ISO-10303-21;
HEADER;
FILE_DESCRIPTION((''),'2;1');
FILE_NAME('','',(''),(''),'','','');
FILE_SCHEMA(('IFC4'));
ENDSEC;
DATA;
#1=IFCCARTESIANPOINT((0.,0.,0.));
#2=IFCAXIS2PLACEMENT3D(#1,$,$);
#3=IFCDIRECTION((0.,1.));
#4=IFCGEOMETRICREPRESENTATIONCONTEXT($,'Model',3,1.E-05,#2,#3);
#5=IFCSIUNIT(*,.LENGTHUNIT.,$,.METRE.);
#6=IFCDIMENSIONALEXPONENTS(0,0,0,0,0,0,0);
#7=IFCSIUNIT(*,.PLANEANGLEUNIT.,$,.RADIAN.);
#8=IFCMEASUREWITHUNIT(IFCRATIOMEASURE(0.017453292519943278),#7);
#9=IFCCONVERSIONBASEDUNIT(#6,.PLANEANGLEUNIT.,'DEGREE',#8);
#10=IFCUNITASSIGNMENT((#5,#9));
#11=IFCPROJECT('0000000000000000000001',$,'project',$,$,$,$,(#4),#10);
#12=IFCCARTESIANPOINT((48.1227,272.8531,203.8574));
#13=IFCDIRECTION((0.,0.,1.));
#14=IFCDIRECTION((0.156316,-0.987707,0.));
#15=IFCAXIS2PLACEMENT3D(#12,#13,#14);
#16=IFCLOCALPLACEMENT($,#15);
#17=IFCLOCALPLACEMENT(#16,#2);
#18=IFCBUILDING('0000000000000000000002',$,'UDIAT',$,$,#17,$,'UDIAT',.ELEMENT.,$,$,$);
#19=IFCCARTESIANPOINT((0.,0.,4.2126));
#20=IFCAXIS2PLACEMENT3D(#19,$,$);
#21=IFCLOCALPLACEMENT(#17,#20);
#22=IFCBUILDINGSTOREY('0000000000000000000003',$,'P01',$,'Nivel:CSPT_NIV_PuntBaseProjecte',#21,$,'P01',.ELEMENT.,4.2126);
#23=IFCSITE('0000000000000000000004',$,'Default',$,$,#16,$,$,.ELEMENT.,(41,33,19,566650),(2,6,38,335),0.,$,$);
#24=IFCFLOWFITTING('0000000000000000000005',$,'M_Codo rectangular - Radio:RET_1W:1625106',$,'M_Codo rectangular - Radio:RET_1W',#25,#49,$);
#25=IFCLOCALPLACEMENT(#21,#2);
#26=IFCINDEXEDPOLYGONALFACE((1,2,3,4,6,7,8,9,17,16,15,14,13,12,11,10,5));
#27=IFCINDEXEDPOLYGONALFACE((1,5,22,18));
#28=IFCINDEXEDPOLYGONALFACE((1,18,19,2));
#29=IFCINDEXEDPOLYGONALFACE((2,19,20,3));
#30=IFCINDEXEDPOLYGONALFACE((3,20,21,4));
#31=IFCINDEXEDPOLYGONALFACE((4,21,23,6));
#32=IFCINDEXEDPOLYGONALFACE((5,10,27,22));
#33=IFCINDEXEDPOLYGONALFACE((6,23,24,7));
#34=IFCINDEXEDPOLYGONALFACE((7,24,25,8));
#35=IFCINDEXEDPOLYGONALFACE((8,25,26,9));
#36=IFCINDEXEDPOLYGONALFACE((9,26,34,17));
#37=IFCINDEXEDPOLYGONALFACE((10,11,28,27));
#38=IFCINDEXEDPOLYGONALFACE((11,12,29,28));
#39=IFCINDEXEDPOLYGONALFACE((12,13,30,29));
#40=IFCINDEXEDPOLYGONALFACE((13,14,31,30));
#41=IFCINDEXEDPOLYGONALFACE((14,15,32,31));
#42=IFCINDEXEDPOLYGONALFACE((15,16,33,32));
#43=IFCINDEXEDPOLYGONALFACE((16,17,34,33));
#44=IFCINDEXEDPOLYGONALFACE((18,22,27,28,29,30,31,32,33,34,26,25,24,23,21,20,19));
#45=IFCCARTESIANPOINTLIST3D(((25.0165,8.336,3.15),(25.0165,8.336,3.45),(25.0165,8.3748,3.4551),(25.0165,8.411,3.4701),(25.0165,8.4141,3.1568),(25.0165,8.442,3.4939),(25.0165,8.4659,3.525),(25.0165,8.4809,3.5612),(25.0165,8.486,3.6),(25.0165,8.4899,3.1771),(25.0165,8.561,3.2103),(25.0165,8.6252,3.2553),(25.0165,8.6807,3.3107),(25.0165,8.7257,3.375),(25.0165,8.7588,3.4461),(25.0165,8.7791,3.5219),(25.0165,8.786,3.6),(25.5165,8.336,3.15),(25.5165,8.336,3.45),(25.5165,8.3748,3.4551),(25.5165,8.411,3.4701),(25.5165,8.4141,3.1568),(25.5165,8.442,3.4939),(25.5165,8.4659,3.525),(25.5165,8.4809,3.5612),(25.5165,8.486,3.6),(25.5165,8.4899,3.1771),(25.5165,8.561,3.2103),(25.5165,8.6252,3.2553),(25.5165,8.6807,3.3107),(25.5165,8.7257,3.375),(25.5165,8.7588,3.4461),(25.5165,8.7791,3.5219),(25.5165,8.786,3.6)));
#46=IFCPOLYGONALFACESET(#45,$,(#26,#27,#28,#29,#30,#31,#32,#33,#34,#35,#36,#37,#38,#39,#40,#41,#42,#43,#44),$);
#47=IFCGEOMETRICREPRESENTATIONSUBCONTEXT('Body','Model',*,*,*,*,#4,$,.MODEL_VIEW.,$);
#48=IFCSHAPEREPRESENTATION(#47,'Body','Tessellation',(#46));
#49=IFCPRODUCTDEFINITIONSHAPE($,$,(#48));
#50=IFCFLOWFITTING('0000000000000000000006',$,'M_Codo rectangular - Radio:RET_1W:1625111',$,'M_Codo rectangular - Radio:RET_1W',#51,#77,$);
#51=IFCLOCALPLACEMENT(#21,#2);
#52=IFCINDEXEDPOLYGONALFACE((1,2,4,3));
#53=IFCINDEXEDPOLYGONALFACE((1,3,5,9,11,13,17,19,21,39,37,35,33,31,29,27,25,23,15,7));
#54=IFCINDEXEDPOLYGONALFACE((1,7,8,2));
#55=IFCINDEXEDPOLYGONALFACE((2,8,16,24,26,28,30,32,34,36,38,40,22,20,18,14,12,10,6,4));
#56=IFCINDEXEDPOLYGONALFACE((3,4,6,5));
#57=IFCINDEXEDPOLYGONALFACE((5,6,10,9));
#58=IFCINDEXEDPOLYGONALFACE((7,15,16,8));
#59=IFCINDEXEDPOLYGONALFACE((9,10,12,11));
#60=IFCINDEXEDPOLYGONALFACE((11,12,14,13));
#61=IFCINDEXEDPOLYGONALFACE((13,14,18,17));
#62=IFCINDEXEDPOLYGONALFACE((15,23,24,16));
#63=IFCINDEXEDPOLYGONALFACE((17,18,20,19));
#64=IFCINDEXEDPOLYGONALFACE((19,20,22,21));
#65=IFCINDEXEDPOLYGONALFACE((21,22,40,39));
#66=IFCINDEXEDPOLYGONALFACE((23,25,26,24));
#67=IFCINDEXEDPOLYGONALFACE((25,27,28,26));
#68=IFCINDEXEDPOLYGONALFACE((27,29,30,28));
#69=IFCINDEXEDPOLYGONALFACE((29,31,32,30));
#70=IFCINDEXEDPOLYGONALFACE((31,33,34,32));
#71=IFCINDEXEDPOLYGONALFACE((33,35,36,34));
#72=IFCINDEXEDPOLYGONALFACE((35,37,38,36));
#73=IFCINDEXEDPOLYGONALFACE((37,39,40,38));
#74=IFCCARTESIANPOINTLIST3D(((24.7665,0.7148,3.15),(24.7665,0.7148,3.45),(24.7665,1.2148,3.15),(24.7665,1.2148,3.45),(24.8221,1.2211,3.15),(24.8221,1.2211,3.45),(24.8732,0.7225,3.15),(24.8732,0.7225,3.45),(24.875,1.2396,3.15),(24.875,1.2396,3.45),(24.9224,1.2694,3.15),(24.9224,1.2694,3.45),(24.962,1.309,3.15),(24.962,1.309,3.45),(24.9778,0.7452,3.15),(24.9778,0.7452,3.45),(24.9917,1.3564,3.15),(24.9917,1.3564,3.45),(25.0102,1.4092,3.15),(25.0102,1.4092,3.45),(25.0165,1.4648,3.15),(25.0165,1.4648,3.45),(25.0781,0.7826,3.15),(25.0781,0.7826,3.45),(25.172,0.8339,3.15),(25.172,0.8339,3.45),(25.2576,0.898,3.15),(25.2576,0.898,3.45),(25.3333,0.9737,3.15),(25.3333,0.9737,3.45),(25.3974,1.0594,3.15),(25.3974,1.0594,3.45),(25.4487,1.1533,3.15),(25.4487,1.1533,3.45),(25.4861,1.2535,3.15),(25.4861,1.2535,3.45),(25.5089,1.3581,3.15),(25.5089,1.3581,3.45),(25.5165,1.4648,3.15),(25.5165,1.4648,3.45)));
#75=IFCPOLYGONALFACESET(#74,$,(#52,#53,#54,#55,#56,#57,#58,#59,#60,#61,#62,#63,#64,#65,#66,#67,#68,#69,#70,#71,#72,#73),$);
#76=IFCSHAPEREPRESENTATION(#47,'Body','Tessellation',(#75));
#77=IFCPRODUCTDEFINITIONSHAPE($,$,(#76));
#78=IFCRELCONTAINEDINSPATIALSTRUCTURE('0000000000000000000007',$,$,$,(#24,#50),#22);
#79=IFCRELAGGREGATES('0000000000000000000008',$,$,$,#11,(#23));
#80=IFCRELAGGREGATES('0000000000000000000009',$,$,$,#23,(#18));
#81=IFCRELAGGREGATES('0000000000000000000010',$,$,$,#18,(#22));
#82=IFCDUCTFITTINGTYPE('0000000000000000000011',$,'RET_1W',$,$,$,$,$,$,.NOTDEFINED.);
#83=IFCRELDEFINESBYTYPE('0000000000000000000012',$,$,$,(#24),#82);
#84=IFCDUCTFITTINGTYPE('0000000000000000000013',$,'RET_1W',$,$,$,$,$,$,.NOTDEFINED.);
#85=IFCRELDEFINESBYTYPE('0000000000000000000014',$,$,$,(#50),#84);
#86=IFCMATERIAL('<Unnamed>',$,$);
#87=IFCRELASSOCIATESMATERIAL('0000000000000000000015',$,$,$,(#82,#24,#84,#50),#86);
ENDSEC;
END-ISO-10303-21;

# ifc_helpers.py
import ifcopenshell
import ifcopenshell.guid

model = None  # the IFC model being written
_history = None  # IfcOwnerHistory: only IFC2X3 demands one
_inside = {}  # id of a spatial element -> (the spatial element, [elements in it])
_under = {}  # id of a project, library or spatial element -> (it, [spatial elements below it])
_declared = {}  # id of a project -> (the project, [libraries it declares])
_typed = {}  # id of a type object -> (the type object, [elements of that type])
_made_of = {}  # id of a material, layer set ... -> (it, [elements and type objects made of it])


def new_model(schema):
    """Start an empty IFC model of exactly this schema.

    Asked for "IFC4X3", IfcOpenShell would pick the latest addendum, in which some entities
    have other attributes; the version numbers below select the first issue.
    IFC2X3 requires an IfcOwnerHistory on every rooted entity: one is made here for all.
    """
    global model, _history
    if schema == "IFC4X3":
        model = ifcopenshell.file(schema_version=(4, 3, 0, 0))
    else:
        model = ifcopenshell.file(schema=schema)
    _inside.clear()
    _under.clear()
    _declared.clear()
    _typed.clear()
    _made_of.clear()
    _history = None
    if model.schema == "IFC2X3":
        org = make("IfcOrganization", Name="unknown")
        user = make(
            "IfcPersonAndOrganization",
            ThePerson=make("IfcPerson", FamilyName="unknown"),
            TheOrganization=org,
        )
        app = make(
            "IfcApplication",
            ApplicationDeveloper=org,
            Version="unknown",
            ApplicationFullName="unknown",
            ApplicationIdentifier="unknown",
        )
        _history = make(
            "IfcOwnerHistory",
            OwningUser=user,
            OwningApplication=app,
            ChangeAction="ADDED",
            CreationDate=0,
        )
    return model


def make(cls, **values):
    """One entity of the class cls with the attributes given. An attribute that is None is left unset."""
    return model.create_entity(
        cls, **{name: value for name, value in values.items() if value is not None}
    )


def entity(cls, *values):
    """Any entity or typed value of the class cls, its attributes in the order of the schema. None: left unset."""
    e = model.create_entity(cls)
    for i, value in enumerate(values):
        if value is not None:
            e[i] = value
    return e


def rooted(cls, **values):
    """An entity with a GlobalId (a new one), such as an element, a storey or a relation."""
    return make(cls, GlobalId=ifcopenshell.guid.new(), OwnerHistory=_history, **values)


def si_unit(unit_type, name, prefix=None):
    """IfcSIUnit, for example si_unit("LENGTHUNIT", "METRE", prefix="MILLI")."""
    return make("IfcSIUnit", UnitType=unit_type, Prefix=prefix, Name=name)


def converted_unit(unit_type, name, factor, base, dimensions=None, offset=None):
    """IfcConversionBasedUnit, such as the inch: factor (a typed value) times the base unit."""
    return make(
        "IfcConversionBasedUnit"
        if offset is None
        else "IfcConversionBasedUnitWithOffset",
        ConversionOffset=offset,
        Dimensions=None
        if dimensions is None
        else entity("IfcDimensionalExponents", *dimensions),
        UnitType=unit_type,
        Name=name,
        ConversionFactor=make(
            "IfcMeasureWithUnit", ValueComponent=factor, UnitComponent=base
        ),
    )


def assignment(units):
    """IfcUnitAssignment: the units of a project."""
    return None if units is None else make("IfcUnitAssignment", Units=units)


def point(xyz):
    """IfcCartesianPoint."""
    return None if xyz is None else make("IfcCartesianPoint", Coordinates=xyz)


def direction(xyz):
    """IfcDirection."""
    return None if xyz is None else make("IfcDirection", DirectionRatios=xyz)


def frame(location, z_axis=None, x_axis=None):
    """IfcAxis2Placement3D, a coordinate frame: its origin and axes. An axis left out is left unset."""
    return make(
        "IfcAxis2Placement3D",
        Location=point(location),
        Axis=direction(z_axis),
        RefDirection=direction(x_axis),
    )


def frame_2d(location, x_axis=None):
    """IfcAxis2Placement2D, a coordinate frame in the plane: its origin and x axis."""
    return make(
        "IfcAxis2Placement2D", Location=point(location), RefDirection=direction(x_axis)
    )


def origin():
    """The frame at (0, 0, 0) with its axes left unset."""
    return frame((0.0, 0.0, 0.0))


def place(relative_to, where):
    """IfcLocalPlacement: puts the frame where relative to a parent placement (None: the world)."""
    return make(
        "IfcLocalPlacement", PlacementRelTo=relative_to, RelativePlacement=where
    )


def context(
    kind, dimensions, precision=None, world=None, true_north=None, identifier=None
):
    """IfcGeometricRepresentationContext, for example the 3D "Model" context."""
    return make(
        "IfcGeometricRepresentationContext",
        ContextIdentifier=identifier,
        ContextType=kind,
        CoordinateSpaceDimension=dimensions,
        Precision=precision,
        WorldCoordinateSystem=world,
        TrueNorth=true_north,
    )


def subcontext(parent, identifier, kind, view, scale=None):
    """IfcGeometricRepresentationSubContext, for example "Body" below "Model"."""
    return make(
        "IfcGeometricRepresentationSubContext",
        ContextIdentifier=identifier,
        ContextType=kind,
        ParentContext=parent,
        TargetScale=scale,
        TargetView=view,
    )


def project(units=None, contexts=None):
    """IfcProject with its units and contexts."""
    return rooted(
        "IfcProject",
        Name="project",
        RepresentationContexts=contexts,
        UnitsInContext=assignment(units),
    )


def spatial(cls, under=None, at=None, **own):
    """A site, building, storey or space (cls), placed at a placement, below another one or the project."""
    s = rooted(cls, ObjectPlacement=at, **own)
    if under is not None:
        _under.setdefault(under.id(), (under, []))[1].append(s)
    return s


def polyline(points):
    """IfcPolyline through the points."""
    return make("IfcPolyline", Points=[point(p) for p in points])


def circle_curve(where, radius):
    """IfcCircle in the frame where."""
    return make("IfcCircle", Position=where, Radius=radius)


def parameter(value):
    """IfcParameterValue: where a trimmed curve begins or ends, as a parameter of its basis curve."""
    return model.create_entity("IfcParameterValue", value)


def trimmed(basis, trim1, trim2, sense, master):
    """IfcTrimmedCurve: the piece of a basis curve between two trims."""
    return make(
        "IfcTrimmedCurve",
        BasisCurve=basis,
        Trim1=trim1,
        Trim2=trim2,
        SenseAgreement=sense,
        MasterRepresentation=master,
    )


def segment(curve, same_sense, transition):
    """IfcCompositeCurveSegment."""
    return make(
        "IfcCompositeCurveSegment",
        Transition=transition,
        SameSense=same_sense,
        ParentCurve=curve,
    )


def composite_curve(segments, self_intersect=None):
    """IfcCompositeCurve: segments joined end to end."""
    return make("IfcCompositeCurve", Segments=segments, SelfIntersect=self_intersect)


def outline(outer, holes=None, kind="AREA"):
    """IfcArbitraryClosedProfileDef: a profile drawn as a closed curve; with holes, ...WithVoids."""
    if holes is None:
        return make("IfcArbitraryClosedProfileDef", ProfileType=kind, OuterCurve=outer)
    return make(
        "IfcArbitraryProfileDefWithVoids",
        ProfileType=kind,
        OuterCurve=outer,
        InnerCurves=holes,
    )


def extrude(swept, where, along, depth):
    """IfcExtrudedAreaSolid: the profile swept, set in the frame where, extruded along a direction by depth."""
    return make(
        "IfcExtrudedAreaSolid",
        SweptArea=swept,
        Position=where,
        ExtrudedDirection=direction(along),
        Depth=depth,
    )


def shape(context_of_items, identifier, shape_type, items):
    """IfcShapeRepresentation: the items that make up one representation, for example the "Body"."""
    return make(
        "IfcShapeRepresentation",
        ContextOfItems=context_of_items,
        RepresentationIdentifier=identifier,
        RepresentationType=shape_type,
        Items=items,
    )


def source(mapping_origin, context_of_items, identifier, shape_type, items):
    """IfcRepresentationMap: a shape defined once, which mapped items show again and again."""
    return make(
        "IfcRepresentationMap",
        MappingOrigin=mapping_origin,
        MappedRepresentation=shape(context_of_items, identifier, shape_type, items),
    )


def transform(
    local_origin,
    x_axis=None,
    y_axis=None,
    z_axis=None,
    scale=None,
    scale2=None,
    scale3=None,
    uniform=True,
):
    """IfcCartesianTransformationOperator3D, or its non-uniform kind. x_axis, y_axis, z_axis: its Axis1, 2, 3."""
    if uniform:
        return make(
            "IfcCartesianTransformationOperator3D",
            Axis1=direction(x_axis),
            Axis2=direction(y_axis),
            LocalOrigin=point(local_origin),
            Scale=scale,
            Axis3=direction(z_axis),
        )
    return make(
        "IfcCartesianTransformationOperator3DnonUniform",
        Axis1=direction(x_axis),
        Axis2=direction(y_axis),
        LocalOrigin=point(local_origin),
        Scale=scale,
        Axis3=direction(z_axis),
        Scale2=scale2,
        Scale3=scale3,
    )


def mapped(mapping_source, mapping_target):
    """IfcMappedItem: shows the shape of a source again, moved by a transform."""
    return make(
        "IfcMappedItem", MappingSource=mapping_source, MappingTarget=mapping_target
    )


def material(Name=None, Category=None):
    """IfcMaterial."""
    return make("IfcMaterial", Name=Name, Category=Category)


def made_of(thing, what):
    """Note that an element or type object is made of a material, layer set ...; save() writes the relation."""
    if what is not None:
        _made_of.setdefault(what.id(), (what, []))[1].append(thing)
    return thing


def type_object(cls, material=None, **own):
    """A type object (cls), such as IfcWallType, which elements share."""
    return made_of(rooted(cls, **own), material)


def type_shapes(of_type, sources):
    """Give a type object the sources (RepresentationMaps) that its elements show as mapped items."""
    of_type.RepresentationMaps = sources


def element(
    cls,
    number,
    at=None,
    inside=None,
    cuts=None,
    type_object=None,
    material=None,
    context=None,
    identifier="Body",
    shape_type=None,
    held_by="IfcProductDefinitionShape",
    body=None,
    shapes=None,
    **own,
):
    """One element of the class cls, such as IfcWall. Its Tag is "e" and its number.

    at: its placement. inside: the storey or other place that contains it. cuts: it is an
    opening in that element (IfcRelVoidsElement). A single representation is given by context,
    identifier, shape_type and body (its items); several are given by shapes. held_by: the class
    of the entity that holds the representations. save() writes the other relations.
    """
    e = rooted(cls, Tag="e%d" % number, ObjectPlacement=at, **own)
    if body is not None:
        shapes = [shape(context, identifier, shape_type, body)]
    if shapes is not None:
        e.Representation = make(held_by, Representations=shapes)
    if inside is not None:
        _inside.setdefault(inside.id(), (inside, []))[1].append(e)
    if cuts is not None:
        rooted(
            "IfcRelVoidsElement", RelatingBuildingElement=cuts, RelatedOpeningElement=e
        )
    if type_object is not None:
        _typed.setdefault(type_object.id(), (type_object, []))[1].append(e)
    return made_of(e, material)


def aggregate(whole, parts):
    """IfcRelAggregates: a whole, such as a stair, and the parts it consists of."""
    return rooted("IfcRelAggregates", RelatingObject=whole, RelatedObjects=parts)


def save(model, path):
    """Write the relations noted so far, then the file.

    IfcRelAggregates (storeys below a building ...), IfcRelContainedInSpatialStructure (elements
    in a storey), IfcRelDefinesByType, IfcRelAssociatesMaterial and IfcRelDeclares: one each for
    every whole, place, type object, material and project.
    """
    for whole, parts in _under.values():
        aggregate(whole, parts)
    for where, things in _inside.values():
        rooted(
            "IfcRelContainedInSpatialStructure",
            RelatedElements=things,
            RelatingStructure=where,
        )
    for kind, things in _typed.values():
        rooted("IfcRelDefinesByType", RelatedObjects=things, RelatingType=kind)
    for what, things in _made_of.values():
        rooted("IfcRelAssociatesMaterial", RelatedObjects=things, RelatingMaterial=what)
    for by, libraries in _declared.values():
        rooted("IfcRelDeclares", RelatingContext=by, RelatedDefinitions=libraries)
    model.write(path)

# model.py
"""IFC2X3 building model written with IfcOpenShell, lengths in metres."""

from ifc_helpers import new_model, entity, si_unit, converted_unit, direction, frame, frame_2d, origin, place, context, subcontext, project, spatial, polyline, circle_curve, parameter, trimmed, segment, composite_curve, outline, extrude, source, transform, mapped, material, type_object, type_shapes, element, save


model = new_model("IFC2X3")

# Units and contexts
model_context = context("Model", 3, precision=1e-05, world=origin(), true_north=direction((0.0, 1.0)))
body_context = subcontext(model_context, "Body", "Model", "MODEL_VIEW")
ifc_project = project(units=[si_unit("LENGTHUNIT", "METRE"), converted_unit("PLANEANGLEUNIT", "DEGREE", entity("IfcRatioMeasure", 0.017453292519943278), si_unit("PLANEANGLEUNIT", "RADIAN"), dimensions=[0, 0, 0, 0, 0, 0, 0])], contexts=[model_context])

# Site, building, storey
site_placement = place(None, frame((48.1227, 272.8531, 203.8574), z_axis=(0.0, 0.0, 1.0), x_axis=(0.156316, -0.987707, 0.0)))
site = spatial("IfcSite", under=ifc_project, at=site_placement, Name="Default", CompositionType="ELEMENT", RefLatitude=(41, 33, 19, 566650), RefLongitude=(2, 6, 38, 335), RefElevation=0.0)
building_placement = place(site_placement, origin())
building = spatial("IfcBuilding", under=site, at=building_placement, Name="UDIAT", LongName="UDIAT", CompositionType="ELEMENT")
storey_placement = place(building_placement, frame((0.0, 0.0, 4.2126)))
storey = spatial("IfcBuildingStorey", under=building, at=storey_placement, Name="P01", ObjectType="Nivel:CSPT_NIV_PuntBaseProjecte", LongName="P01", CompositionType="ELEMENT", Elevation=4.2126)

# Flow fittings
ifc_material_1 = material(Name="<Unnamed>")
duct_fitting_type_1 = type_object("IfcDuctFittingType", Name="RET_1W", PredefinedType="NOTDEFINED", material=ifc_material_1)
shared_shape_1 = source(origin(), body_context, "Body", "SweptSolid", [
    extrude(outline(composite_curve([segment(polyline([(-0.3, -0.15), (0.0, -0.15)]), True, "CONTINUOUS"), segment(trimmed(circle_curve(frame_2d((0.15, -0.15), x_axis=(0.0, 1.0)), 0.15), [parameter(0.0)], [parameter(90.0)], True, "PARAMETER"), False, "CONTINUOUS"), segment(polyline([(0.15, 0.0), (0.15, 0.3)]), True, "CONTINUOUS"), segment(trimmed(circle_curve(frame_2d((0.15, -0.15), x_axis=(0.0, 1.0)), 0.45), [parameter(0.0)], [parameter(90.0)], True, "PARAMETER"), True, "CONTINUOUS")], self_intersect=False)), frame((-0.15, 0.15, -0.25), z_axis=(0.0, 0.0, 1.0), x_axis=(-1.0, 0.0, 0.0)), (0.0, 0.0, 1.0), 0.5),
])
type_shapes(duct_fitting_type_1, [shared_shape_1])
flow_fitting_1_placement = place(storey_placement, frame((25.2665, 8.636, 3.3), z_axis=(1.0, 0.0, 0.0), x_axis=(0.0, 1.0, 0.0)))
element("IfcFlowFitting", 1, at=flow_fitting_1_placement, inside=storey, type_object=duct_fitting_type_1, material=ifc_material_1, Name="M_Codo rectangular - Radio:RET_1W:1625106", ObjectType="M_Codo rectangular - Radio:RET_1W", context=body_context, shape_type="MappedRepresentation", body=[
    mapped(shared_shape_1, transform((0.0, 0.0, 0.0), scale=1.0)),
])
duct_fitting_type_2 = type_object("IfcDuctFittingType", Name="RET_1W", PredefinedType="NOTDEFINED", material=ifc_material_1)
shared_shape_2 = source(origin(), body_context, "Body", "SweptSolid", [
    extrude(outline(composite_curve([segment(polyline([(-0.5, -0.25), (0.0, -0.25)]), True, "CONTINUOUS"), segment(trimmed(circle_curve(frame_2d((0.25, -0.25), x_axis=(0.0, 1.0)), 0.25), [parameter(0.0)], [parameter(90.0)], True, "PARAMETER"), False, "CONTINUOUS"), segment(polyline([(0.25, 0.0), (0.25, 0.5)]), True, "CONTINUOUS"), segment(trimmed(circle_curve(frame_2d((0.25, -0.25), x_axis=(0.0, 1.0)), 0.75), [parameter(0.0)], [parameter(90.0)], True, "PARAMETER"), True, "CONTINUOUS")], self_intersect=False)), frame((-0.25, 0.25, -0.15), z_axis=(0.0, 0.0, 1.0), x_axis=(-1.0, 0.0, 0.0)), (0.0, 0.0, 1.0), 0.3),
])
type_shapes(duct_fitting_type_2, [shared_shape_2])
flow_fitting_2_placement = place(storey_placement, frame((25.2665, 0.9648, 3.3)))
element("IfcFlowFitting", 2, at=flow_fitting_2_placement, inside=storey, type_object=duct_fitting_type_2, material=ifc_material_1, Name="M_Codo rectangular - Radio:RET_1W:1625111", ObjectType="M_Codo rectangular - Radio:RET_1W", context=body_context, shape_type="MappedRepresentation", body=[
    mapped(shared_shape_2, transform((0.0, 0.0, 0.0), scale=1.0)),
])

save(model, "model.ifc")
